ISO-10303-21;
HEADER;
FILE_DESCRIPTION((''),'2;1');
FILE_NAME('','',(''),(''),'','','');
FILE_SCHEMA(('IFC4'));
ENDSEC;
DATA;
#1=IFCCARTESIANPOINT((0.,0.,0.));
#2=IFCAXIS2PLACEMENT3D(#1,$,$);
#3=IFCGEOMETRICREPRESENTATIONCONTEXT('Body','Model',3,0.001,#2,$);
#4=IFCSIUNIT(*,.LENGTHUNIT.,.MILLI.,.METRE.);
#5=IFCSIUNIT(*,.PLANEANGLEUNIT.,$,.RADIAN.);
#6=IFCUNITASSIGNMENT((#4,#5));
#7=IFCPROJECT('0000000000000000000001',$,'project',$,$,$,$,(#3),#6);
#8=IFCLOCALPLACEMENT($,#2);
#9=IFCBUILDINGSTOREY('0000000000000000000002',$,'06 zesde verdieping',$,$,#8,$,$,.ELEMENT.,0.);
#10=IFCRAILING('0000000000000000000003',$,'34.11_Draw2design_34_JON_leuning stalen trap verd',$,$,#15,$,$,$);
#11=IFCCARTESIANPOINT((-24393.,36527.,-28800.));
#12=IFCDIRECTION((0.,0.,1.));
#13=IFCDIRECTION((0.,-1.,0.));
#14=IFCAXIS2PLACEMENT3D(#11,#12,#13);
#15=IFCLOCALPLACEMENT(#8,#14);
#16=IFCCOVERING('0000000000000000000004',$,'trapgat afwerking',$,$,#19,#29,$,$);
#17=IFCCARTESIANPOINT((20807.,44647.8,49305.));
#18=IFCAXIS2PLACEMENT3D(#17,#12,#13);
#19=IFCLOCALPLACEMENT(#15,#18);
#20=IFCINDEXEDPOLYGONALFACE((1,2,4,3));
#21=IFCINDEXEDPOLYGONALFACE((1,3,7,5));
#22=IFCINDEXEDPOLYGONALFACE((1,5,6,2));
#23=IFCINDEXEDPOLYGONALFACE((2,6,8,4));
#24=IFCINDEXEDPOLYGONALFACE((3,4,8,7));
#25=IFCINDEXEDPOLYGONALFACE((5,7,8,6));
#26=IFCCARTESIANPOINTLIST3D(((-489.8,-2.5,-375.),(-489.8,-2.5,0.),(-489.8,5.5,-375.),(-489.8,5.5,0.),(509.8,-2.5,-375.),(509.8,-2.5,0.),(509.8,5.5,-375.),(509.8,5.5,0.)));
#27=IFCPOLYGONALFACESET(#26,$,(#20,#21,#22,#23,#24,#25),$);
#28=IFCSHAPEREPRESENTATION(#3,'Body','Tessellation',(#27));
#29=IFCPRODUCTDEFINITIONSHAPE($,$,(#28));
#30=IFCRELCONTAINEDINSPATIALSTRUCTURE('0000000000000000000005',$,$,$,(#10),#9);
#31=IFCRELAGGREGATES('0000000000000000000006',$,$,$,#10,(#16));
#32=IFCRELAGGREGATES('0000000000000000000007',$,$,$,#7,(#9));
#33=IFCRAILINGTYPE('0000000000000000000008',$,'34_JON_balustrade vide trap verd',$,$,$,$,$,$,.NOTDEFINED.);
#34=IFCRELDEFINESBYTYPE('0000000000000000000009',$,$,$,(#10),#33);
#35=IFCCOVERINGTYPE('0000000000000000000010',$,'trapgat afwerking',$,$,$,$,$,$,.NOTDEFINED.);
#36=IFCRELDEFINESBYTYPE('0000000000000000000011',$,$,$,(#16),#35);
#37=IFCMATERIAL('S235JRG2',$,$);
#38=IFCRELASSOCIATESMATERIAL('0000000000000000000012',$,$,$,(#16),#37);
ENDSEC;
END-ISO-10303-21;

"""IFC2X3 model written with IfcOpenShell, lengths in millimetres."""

from ifc_helpers import new_model, si_unit, frame, origin, place, context, project, spatial, polyline, outline, extrude, source, transform, mapped, material, type_object, element, aggregate, save


model = new_model("IFC2X3")

# Units and contexts
model_context = context("Model", 3, precision=0.001, world=origin(), identifier="Body")
ifc_project = project(units=[si_unit("LENGTHUNIT", "METRE", prefix="MILLI"), si_unit("PLANEANGLEUNIT", "RADIAN")], contexts=[model_context])

# Storey
storey_placement = place(None, origin())
storey = spatial("IfcBuildingStorey", under=ifc_project, at=storey_placement, Name="06 zesde verdieping", CompositionType="ELEMENT", Elevation=0.0)

# Railing
railing_type_1 = type_object("IfcRailingType", Name="34_JON_balustrade vide trap verd")
railing_1_placement = place(storey_placement, frame((-24393.0, 36527.0, -28800.0), z_axis=(0.0, 0.0, 1.0), x_axis=(0.0, -1.0, 0.0)))
railing_1 = element("IfcRailing", 1, at=railing_1_placement, inside=storey, type_object=railing_type_1, Name="34.11_Draw2design_34_JON_leuning stalen trap verd")

# Shared definitions
ifc_material_1 = material(Name="S235JRG2")

# Covering
covering_type = type_object("IfcCoveringType", Name="trapgat afwerking")
shared_shape_1 = source(origin(), model_context, "Body", "SweptSolid", [
    extrude(outline(polyline([(-489.8, -2.5), (509.8, -2.5), (509.8, 5.5), (-489.8, 5.5), (-489.8, -2.5)])), origin(), (0.0, 0.0, -1.0), 375.0),
])
covering_placement = place(railing_1_placement, frame((20807.0, 44647.8, 49305.0), z_axis=(0.0, 0.0, 1.0), x_axis=(0.0, -1.0, 0.0)))
covering = element("IfcCovering", 2, at=covering_placement, type_object=covering_type, material=ifc_material_1, Name="trapgat afwerking", context=model_context, shape_type="MappedRepresentation", body=[
    mapped(shared_shape_1, transform((0.0, 0.0, 0.0), scale=1.0)),
])
aggregate(railing_1, [covering])

save(model, "model.ifc")
